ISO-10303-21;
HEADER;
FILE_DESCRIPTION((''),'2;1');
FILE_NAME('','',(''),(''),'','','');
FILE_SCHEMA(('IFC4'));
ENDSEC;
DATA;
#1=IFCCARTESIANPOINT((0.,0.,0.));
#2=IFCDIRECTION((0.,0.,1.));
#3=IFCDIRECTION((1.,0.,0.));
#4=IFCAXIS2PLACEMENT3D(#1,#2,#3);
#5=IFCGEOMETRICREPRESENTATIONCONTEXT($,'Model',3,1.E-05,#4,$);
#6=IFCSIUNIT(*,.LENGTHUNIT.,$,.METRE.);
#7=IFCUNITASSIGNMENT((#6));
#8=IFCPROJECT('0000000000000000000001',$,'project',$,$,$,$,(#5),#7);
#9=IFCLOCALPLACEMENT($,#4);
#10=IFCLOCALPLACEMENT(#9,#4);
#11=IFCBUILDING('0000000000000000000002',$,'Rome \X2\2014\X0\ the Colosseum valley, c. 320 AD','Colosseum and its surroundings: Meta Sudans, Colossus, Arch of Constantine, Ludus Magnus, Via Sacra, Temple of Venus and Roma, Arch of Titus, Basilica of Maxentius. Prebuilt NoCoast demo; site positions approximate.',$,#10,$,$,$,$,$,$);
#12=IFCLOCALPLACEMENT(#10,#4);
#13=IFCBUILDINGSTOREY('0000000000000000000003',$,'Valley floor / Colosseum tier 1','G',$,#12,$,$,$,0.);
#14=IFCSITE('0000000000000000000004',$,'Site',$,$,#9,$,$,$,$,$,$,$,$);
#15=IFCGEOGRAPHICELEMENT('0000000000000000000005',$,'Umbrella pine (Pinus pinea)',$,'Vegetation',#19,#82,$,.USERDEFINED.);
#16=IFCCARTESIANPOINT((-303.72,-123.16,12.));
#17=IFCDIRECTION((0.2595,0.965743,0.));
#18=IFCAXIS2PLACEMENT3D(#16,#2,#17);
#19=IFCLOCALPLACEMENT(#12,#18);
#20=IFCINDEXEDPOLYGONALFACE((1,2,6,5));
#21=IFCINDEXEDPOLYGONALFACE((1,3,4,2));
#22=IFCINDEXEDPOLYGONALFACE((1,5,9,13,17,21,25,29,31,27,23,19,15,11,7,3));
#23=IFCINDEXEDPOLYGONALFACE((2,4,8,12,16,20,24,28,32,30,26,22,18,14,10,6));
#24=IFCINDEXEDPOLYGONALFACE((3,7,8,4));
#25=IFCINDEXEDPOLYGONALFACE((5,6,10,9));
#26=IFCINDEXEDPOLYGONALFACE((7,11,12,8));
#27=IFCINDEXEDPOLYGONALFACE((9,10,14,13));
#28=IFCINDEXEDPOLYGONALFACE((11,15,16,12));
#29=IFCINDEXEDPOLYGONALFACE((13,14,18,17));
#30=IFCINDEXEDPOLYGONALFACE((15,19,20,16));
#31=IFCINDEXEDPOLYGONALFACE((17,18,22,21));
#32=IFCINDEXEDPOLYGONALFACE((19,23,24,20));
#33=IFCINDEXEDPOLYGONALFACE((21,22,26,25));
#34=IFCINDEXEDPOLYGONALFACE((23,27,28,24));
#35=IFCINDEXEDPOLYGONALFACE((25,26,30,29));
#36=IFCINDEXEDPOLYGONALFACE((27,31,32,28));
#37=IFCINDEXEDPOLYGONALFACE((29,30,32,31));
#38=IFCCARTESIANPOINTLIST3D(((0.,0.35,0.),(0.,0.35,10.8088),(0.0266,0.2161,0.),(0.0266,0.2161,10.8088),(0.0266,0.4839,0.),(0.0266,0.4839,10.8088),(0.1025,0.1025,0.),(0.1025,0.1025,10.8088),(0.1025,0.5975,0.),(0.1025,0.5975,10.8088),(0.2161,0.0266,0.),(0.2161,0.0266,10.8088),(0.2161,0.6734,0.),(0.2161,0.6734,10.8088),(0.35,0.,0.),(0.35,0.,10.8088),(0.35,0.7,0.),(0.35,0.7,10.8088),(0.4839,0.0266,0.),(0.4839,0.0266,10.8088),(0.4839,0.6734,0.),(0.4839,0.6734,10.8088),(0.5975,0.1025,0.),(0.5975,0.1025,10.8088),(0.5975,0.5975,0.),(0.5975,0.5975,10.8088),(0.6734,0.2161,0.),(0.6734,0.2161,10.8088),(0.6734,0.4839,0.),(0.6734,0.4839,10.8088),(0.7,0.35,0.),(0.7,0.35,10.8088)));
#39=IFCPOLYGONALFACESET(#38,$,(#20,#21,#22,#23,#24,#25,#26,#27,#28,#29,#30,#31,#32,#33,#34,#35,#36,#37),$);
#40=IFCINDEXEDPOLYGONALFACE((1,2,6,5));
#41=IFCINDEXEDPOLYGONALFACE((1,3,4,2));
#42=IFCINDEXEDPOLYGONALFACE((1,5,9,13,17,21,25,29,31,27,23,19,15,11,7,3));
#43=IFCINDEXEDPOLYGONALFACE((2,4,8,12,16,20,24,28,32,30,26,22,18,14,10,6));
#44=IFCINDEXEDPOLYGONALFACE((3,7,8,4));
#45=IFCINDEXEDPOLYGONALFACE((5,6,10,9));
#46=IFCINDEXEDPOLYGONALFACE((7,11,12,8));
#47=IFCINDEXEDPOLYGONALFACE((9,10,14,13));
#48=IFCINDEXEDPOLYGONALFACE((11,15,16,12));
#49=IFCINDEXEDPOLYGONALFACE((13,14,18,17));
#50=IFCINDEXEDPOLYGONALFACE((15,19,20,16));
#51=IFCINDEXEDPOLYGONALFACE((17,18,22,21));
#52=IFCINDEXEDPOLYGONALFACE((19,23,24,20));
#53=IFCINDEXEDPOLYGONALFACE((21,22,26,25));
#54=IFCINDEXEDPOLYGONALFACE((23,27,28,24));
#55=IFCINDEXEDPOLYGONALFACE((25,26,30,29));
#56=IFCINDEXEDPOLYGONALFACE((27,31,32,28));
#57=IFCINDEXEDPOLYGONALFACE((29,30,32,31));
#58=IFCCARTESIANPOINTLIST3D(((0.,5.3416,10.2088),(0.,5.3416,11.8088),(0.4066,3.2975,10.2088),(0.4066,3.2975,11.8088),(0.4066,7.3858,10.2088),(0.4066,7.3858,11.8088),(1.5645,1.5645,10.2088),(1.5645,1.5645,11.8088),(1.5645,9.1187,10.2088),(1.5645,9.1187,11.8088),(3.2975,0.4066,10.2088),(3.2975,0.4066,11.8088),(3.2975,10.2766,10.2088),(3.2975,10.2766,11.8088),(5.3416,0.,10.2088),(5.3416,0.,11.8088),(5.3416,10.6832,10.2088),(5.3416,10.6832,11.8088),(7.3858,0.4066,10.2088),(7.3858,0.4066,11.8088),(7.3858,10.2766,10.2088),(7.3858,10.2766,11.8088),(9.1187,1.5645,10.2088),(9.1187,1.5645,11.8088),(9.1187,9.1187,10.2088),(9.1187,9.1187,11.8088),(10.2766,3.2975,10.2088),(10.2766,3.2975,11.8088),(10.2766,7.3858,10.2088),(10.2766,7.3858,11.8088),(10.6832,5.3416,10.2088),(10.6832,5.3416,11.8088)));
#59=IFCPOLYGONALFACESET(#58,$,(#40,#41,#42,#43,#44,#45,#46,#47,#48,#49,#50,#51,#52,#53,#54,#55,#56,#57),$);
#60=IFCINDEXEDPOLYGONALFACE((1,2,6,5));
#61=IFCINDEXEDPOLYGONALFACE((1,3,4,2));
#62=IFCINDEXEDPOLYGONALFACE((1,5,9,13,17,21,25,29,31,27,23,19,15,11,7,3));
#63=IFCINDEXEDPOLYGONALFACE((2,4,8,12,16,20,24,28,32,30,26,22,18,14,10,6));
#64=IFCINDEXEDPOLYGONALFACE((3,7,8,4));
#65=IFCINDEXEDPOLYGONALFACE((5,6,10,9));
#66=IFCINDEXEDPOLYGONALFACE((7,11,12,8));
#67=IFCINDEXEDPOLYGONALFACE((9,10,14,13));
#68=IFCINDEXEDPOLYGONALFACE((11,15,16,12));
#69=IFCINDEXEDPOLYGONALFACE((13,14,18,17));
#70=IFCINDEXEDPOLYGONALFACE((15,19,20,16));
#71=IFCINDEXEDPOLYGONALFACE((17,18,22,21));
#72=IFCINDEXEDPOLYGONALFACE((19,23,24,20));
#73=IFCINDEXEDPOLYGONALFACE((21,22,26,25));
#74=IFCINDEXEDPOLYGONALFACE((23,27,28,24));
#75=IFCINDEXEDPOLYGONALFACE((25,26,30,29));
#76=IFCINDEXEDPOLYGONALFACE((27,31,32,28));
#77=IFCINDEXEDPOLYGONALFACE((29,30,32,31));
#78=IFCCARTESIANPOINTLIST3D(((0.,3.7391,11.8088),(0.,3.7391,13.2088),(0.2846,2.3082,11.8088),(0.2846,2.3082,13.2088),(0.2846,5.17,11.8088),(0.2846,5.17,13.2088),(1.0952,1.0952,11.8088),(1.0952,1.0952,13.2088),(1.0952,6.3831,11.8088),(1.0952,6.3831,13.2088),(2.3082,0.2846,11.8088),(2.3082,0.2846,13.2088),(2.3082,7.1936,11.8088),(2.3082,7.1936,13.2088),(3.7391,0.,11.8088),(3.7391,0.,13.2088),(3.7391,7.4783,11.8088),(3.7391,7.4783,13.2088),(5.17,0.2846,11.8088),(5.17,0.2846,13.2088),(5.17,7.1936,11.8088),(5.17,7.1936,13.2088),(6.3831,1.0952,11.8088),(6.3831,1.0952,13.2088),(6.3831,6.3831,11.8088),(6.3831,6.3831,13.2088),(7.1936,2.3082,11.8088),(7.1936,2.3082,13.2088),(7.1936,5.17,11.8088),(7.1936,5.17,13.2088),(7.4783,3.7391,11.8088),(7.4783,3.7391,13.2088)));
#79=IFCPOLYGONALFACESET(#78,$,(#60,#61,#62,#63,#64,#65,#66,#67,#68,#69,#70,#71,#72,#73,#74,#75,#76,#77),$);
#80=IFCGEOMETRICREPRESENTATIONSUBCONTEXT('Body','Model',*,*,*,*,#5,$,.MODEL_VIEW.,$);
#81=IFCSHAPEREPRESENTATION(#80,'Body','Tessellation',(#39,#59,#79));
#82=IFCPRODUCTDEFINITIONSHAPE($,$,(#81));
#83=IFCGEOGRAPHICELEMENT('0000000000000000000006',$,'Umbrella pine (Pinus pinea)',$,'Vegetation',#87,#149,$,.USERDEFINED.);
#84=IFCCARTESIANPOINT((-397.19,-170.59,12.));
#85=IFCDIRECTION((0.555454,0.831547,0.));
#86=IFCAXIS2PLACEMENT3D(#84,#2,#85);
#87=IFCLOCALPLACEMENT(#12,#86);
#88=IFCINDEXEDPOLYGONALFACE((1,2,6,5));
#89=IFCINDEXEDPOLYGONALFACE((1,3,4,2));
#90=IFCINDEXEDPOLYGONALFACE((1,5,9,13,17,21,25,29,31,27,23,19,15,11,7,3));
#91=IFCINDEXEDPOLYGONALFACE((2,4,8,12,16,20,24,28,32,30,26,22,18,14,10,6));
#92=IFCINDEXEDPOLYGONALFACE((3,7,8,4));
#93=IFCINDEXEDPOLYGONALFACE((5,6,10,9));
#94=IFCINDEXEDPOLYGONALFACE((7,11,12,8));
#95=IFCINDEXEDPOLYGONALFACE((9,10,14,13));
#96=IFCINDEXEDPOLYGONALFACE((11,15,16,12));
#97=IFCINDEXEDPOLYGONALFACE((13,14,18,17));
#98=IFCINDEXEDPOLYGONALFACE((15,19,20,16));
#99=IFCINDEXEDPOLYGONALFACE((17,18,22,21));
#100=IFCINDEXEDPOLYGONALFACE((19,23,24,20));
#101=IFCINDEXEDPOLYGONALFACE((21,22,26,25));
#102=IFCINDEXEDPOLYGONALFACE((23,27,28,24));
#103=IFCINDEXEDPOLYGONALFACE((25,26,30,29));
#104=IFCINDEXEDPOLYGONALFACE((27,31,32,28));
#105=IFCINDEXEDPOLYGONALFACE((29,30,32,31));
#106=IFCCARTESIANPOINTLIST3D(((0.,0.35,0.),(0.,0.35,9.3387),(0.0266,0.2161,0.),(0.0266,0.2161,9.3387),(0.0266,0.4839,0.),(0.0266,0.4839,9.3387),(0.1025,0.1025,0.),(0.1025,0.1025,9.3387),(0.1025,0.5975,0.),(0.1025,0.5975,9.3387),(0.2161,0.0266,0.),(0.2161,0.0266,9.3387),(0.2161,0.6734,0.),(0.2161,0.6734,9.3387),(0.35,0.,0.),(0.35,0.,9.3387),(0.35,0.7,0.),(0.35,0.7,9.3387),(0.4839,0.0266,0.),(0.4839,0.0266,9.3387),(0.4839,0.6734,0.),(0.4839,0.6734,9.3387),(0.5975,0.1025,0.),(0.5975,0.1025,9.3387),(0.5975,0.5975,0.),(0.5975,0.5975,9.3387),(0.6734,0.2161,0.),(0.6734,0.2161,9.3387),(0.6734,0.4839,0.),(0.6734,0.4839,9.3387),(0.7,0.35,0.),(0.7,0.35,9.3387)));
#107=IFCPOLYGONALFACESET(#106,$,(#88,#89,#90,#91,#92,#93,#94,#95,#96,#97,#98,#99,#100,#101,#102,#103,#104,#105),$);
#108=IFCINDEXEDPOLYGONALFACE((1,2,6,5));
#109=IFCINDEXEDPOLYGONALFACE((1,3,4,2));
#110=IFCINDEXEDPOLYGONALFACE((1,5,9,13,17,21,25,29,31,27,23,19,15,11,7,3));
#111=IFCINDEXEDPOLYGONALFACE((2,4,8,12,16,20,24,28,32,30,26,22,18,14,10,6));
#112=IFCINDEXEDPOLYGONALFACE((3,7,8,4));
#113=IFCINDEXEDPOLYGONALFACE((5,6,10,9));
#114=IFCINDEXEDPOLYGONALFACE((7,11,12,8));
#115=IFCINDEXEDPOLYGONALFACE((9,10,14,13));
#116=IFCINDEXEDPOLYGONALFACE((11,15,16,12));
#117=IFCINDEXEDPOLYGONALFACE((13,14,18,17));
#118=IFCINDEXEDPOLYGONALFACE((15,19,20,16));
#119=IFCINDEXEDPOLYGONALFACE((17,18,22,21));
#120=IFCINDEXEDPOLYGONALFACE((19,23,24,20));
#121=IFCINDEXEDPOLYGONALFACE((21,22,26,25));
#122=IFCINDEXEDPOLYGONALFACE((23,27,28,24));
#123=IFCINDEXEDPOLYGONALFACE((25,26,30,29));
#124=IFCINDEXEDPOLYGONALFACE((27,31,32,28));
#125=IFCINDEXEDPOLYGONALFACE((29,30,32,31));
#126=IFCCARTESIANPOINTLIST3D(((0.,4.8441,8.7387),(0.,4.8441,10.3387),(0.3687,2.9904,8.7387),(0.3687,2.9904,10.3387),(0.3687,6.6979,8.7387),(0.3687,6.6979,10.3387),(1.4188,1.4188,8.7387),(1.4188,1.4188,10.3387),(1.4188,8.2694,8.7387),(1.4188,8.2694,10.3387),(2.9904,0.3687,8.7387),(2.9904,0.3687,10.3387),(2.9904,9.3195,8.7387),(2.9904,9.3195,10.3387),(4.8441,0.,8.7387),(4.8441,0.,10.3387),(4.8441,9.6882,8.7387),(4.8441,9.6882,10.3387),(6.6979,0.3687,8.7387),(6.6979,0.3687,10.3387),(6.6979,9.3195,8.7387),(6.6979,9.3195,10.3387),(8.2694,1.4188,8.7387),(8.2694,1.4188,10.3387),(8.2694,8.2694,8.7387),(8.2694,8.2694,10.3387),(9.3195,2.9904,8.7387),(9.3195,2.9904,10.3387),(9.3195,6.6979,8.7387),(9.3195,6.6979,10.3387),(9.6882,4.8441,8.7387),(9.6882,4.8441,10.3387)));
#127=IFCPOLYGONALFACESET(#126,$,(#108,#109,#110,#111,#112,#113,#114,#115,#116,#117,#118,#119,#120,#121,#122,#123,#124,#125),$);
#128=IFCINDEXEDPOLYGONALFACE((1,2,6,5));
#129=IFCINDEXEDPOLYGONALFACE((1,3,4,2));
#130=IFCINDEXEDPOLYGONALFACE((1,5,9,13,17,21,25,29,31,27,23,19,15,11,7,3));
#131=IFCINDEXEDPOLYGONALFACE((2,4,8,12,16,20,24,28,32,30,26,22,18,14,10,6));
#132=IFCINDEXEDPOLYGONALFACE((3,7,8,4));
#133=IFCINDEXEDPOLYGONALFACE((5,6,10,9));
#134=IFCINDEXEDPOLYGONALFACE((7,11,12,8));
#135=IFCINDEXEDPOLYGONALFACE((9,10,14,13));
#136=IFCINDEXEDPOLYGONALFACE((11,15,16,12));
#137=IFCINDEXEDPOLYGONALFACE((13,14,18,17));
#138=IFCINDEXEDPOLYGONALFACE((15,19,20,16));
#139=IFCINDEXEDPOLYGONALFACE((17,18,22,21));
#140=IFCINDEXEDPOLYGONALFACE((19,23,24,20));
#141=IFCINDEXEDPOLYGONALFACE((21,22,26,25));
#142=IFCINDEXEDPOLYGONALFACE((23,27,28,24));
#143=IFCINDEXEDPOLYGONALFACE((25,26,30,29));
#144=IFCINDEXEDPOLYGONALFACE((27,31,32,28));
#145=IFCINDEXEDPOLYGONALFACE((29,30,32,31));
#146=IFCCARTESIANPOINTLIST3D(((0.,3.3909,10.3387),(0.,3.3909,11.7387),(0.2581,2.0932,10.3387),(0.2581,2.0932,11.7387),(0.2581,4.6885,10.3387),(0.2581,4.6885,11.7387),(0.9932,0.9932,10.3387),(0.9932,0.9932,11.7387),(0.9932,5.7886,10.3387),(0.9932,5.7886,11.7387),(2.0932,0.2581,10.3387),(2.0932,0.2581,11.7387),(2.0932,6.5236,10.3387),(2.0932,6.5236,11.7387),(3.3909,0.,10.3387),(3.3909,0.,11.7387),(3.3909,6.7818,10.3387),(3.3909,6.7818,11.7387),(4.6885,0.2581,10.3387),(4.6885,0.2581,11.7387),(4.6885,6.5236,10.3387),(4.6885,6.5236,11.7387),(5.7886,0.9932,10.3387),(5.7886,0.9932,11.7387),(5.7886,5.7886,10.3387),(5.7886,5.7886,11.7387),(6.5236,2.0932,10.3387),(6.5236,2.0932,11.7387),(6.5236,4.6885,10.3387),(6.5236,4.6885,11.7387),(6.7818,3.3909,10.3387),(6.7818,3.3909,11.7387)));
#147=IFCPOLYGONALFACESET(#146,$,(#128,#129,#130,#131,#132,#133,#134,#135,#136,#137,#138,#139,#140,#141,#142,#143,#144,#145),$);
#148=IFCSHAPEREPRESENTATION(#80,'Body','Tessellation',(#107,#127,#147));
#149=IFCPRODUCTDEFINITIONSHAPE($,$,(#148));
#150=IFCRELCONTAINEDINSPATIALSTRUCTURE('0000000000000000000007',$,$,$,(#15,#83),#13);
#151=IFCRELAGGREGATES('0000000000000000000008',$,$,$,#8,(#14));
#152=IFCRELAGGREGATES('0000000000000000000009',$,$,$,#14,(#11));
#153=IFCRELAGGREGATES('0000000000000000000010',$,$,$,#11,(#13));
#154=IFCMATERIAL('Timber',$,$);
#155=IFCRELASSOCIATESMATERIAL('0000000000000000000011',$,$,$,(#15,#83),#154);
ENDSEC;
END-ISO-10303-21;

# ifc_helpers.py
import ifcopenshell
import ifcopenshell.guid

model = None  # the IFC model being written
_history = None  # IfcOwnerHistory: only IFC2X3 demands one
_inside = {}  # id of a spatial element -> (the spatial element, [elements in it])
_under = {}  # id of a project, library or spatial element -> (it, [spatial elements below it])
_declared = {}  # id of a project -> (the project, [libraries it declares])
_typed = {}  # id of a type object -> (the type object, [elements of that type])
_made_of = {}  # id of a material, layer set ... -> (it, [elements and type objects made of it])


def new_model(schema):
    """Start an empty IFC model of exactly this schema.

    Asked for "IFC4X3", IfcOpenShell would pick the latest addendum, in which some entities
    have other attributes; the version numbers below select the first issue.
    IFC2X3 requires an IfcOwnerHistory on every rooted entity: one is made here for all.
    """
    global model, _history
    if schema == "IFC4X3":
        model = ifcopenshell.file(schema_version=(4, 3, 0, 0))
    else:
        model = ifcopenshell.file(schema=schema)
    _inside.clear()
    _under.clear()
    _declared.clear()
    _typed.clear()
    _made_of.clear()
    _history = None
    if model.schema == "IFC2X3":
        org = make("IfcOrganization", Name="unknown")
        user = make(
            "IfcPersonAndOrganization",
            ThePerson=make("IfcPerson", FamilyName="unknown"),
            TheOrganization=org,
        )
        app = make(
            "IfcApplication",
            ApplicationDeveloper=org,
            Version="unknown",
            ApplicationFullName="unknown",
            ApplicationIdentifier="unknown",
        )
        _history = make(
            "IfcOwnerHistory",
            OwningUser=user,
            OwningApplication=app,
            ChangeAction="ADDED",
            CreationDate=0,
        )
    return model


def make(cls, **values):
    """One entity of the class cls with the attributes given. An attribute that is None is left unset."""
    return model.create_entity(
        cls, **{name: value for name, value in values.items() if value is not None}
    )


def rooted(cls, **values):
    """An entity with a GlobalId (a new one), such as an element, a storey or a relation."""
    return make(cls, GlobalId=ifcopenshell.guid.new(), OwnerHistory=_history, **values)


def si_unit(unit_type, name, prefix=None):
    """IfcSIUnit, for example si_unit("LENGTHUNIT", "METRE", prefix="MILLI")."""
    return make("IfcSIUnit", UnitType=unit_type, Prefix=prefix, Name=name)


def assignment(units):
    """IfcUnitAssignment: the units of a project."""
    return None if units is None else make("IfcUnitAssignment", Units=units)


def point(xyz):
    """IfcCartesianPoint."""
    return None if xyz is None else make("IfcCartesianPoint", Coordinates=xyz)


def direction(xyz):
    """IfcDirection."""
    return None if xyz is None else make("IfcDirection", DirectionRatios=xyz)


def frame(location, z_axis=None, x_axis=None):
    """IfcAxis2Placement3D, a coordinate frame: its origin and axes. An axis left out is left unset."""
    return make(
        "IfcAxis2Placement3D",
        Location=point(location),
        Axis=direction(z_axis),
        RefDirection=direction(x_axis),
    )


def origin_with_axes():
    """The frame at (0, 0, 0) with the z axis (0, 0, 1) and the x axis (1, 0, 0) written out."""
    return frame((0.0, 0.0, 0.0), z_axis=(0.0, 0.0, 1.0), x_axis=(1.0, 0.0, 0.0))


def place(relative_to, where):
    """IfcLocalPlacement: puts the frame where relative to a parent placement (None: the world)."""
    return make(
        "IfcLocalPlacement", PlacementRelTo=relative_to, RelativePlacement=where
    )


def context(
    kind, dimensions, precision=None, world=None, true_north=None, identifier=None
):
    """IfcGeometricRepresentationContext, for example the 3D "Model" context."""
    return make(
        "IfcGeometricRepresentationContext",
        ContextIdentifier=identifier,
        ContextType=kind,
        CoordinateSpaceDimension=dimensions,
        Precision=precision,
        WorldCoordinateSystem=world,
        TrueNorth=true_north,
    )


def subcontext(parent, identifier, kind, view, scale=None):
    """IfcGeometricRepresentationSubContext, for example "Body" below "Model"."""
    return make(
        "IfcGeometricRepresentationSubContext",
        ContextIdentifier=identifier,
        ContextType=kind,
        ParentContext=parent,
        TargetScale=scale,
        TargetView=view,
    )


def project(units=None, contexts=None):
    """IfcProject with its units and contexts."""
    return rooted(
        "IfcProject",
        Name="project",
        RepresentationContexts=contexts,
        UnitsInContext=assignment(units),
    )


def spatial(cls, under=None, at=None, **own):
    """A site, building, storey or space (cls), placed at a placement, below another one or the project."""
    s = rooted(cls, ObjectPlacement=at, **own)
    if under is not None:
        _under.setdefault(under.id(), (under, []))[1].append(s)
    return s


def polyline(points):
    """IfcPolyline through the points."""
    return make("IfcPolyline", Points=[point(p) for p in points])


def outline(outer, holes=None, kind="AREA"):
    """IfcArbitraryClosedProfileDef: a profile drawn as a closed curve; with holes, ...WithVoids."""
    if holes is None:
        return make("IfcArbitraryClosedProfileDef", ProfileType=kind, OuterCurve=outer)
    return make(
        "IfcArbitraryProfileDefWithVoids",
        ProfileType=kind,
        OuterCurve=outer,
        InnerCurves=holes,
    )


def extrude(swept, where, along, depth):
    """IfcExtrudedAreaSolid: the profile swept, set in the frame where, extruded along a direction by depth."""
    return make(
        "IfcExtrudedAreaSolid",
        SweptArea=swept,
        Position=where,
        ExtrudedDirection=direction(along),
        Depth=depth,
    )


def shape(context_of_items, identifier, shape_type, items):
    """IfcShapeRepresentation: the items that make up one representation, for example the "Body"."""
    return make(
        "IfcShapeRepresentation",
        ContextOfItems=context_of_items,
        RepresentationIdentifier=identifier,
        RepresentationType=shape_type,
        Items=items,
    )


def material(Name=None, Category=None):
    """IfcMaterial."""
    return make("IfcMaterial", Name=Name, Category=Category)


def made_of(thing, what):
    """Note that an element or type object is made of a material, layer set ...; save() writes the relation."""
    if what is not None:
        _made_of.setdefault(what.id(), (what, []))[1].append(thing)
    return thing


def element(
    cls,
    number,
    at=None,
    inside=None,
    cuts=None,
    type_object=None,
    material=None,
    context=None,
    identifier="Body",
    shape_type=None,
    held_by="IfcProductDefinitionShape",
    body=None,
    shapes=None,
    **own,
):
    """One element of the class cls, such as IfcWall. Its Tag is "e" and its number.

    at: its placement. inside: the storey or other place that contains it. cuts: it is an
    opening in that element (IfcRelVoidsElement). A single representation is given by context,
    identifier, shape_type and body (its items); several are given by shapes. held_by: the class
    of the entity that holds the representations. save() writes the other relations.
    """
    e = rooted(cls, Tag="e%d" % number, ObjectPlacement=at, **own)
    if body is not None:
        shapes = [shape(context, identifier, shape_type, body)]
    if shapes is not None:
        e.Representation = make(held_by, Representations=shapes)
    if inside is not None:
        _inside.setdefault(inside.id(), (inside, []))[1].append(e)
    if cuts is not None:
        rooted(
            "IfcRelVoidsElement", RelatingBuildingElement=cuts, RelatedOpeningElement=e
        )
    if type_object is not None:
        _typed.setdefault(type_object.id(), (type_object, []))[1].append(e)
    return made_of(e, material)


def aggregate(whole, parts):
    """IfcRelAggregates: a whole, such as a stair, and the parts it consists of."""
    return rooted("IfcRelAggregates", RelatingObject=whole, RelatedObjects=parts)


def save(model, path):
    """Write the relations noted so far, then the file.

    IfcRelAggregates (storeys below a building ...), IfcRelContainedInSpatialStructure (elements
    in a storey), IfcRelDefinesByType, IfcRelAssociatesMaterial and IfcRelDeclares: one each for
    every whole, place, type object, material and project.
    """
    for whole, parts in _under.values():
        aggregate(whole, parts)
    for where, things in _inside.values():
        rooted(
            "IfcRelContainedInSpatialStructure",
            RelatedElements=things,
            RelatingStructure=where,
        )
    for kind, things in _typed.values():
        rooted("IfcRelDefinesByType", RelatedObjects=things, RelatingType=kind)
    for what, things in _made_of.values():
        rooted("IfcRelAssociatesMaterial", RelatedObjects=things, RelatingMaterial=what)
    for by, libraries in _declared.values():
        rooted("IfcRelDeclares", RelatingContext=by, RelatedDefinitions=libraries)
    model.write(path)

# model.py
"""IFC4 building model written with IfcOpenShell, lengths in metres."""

from ifc_helpers import new_model, si_unit, frame, origin_with_axes, place, context, subcontext, project, spatial, polyline, outline, extrude, material, element, save


model = new_model("IFC4")

# Units and contexts
model_context = context("Model", 3, precision=1e-05, world=origin_with_axes())
body_context = subcontext(model_context, "Body", "Model", "MODEL_VIEW")
ifc_project = project(units=[si_unit("LENGTHUNIT", "METRE")], contexts=[model_context])

# Site, building, storey
site_placement = place(None, origin_with_axes())
site = spatial("IfcSite", under=ifc_project, at=site_placement, Name="Site")
building_placement = place(site_placement, origin_with_axes())
building = spatial("IfcBuilding", under=site, at=building_placement, Name="Rome — the Colosseum valley, c. 320 AD", Description="Colosseum and its surroundings: Meta Sudans, Colossus, Arch of Constantine, Ludus Magnus, Via Sacra, Temple of Venus and Roma, Arch of Titus, Basilica of Maxentius. Prebuilt NoCoast demo; site positions approximate.")
storey_placement = place(building_placement, origin_with_axes())
storey = spatial("IfcBuildingStorey", under=building, at=storey_placement, Name="Valley floor / Colosseum tier 1", Description="G", Elevation=0.0)

# Shared definitions
ifc_material_1 = material(Name="Timber")

# Geographic elements
geographic_element_1_placement = place(storey_placement, frame((-303.72, -123.16, 12.0), z_axis=(0.0, 0.0, 1.0), x_axis=(0.2595, 0.965743, 0.0)))
element("IfcGeographicElement", 1, at=geographic_element_1_placement, inside=storey, material=ifc_material_1, Name="Umbrella pine (Pinus pinea)", ObjectType="Vegetation", PredefinedType="USERDEFINED", context=body_context, shape_type="SweptSolid", body=[
    extrude(outline(polyline([(0.7, 0.35), (0.6734, 0.4839), (0.5975, 0.5975), (0.4839, 0.6734), (0.35, 0.7), (0.2161, 0.6734), (0.1025, 0.5975), (0.0266, 0.4839), (0.0, 0.35), (0.0266, 0.2161), (0.1025, 0.1025), (0.2161, 0.0266), (0.35, 0.0), (0.4839, 0.0266), (0.5975, 0.1025), (0.6734, 0.2161), (0.7, 0.35)])), origin_with_axes(), (0.0, 0.0, 1.0), 10.8088),
    extrude(outline(polyline([(10.6832, 5.3416), (10.2766, 7.3858), (9.1187, 9.1187), (7.3858, 10.2766), (5.3416, 10.6832), (3.2975, 10.2766), (1.5645, 9.1187), (0.4066, 7.3858), (0.0, 5.3416), (0.4066, 3.2975), (1.5645, 1.5645), (3.2975, 0.4066), (5.3416, 0.0), (7.3858, 0.4066), (9.1187, 1.5645), (10.2766, 3.2975), (10.6832, 5.3416)])), frame((0.0, 0.0, 10.2088), z_axis=(0.0, 0.0, 1.0), x_axis=(1.0, 0.0, 0.0)), (0.0, 0.0, 1.0), 1.6),
    extrude(outline(polyline([(7.4783, 3.7391), (7.1936, 5.17), (6.3831, 6.3831), (5.17, 7.1936), (3.7391, 7.4783), (2.3082, 7.1936), (1.0952, 6.3831), (0.2846, 5.17), (0.0, 3.7391), (0.2846, 2.3082), (1.0952, 1.0952), (2.3082, 0.2846), (3.7391, 0.0), (5.17, 0.2846), (6.3831, 1.0952), (7.1936, 2.3082), (7.4783, 3.7391)])), frame((0.0, 0.0, 11.8088), z_axis=(0.0, 0.0, 1.0), x_axis=(1.0, 0.0, 0.0)), (0.0, 0.0, 1.0), 1.4),
])
geographic_element_2_placement = place(storey_placement, frame((-397.19, -170.59, 12.0), z_axis=(0.0, 0.0, 1.0), x_axis=(0.555454, 0.831547, 0.0)))
element("IfcGeographicElement", 2, at=geographic_element_2_placement, inside=storey, material=ifc_material_1, Name="Umbrella pine (Pinus pinea)", ObjectType="Vegetation", PredefinedType="USERDEFINED", context=body_context, shape_type="SweptSolid", body=[
    extrude(outline(polyline([(0.7, 0.35), (0.6734, 0.4839), (0.5975, 0.5975), (0.4839, 0.6734), (0.35, 0.7), (0.2161, 0.6734), (0.1025, 0.5975), (0.0266, 0.4839), (0.0, 0.35), (0.0266, 0.2161), (0.1025, 0.1025), (0.2161, 0.0266), (0.35, 0.0), (0.4839, 0.0266), (0.5975, 0.1025), (0.6734, 0.2161), (0.7, 0.35)])), origin_with_axes(), (0.0, 0.0, 1.0), 9.3387),
    extrude(outline(polyline([(9.6882, 4.8441), (9.3195, 6.6979), (8.2694, 8.2694), (6.6979, 9.3195), (4.8441, 9.6882), (2.9904, 9.3195), (1.4188, 8.2694), (0.3687, 6.6979), (0.0, 4.8441), (0.3687, 2.9904), (1.4188, 1.4188), (2.9904, 0.3687), (4.8441, 0.0), (6.6979, 0.3687), (8.2694, 1.4188), (9.3195, 2.9904), (9.6882, 4.8441)])), frame((0.0, 0.0, 8.7387), z_axis=(0.0, 0.0, 1.0), x_axis=(1.0, 0.0, 0.0)), (0.0, 0.0, 1.0), 1.6),
    extrude(outline(polyline([(6.7818, 3.3909), (6.5236, 4.6885), (5.7886, 5.7886), (4.6885, 6.5236), (3.3909, 6.7818), (2.0932, 6.5236), (0.9932, 5.7886), (0.2581, 4.6885), (0.0, 3.3909), (0.2581, 2.0932), (0.9932, 0.9932), (2.0932, 0.2581), (3.3909, 0.0), (4.6885, 0.2581), (5.7886, 0.9932), (6.5236, 2.0932), (6.7818, 3.3909)])), frame((0.0, 0.0, 10.3387), z_axis=(0.0, 0.0, 1.0), x_axis=(1.0, 0.0, 0.0)), (0.0, 0.0, 1.0), 1.4),
])

save(model, "model.ifc")
